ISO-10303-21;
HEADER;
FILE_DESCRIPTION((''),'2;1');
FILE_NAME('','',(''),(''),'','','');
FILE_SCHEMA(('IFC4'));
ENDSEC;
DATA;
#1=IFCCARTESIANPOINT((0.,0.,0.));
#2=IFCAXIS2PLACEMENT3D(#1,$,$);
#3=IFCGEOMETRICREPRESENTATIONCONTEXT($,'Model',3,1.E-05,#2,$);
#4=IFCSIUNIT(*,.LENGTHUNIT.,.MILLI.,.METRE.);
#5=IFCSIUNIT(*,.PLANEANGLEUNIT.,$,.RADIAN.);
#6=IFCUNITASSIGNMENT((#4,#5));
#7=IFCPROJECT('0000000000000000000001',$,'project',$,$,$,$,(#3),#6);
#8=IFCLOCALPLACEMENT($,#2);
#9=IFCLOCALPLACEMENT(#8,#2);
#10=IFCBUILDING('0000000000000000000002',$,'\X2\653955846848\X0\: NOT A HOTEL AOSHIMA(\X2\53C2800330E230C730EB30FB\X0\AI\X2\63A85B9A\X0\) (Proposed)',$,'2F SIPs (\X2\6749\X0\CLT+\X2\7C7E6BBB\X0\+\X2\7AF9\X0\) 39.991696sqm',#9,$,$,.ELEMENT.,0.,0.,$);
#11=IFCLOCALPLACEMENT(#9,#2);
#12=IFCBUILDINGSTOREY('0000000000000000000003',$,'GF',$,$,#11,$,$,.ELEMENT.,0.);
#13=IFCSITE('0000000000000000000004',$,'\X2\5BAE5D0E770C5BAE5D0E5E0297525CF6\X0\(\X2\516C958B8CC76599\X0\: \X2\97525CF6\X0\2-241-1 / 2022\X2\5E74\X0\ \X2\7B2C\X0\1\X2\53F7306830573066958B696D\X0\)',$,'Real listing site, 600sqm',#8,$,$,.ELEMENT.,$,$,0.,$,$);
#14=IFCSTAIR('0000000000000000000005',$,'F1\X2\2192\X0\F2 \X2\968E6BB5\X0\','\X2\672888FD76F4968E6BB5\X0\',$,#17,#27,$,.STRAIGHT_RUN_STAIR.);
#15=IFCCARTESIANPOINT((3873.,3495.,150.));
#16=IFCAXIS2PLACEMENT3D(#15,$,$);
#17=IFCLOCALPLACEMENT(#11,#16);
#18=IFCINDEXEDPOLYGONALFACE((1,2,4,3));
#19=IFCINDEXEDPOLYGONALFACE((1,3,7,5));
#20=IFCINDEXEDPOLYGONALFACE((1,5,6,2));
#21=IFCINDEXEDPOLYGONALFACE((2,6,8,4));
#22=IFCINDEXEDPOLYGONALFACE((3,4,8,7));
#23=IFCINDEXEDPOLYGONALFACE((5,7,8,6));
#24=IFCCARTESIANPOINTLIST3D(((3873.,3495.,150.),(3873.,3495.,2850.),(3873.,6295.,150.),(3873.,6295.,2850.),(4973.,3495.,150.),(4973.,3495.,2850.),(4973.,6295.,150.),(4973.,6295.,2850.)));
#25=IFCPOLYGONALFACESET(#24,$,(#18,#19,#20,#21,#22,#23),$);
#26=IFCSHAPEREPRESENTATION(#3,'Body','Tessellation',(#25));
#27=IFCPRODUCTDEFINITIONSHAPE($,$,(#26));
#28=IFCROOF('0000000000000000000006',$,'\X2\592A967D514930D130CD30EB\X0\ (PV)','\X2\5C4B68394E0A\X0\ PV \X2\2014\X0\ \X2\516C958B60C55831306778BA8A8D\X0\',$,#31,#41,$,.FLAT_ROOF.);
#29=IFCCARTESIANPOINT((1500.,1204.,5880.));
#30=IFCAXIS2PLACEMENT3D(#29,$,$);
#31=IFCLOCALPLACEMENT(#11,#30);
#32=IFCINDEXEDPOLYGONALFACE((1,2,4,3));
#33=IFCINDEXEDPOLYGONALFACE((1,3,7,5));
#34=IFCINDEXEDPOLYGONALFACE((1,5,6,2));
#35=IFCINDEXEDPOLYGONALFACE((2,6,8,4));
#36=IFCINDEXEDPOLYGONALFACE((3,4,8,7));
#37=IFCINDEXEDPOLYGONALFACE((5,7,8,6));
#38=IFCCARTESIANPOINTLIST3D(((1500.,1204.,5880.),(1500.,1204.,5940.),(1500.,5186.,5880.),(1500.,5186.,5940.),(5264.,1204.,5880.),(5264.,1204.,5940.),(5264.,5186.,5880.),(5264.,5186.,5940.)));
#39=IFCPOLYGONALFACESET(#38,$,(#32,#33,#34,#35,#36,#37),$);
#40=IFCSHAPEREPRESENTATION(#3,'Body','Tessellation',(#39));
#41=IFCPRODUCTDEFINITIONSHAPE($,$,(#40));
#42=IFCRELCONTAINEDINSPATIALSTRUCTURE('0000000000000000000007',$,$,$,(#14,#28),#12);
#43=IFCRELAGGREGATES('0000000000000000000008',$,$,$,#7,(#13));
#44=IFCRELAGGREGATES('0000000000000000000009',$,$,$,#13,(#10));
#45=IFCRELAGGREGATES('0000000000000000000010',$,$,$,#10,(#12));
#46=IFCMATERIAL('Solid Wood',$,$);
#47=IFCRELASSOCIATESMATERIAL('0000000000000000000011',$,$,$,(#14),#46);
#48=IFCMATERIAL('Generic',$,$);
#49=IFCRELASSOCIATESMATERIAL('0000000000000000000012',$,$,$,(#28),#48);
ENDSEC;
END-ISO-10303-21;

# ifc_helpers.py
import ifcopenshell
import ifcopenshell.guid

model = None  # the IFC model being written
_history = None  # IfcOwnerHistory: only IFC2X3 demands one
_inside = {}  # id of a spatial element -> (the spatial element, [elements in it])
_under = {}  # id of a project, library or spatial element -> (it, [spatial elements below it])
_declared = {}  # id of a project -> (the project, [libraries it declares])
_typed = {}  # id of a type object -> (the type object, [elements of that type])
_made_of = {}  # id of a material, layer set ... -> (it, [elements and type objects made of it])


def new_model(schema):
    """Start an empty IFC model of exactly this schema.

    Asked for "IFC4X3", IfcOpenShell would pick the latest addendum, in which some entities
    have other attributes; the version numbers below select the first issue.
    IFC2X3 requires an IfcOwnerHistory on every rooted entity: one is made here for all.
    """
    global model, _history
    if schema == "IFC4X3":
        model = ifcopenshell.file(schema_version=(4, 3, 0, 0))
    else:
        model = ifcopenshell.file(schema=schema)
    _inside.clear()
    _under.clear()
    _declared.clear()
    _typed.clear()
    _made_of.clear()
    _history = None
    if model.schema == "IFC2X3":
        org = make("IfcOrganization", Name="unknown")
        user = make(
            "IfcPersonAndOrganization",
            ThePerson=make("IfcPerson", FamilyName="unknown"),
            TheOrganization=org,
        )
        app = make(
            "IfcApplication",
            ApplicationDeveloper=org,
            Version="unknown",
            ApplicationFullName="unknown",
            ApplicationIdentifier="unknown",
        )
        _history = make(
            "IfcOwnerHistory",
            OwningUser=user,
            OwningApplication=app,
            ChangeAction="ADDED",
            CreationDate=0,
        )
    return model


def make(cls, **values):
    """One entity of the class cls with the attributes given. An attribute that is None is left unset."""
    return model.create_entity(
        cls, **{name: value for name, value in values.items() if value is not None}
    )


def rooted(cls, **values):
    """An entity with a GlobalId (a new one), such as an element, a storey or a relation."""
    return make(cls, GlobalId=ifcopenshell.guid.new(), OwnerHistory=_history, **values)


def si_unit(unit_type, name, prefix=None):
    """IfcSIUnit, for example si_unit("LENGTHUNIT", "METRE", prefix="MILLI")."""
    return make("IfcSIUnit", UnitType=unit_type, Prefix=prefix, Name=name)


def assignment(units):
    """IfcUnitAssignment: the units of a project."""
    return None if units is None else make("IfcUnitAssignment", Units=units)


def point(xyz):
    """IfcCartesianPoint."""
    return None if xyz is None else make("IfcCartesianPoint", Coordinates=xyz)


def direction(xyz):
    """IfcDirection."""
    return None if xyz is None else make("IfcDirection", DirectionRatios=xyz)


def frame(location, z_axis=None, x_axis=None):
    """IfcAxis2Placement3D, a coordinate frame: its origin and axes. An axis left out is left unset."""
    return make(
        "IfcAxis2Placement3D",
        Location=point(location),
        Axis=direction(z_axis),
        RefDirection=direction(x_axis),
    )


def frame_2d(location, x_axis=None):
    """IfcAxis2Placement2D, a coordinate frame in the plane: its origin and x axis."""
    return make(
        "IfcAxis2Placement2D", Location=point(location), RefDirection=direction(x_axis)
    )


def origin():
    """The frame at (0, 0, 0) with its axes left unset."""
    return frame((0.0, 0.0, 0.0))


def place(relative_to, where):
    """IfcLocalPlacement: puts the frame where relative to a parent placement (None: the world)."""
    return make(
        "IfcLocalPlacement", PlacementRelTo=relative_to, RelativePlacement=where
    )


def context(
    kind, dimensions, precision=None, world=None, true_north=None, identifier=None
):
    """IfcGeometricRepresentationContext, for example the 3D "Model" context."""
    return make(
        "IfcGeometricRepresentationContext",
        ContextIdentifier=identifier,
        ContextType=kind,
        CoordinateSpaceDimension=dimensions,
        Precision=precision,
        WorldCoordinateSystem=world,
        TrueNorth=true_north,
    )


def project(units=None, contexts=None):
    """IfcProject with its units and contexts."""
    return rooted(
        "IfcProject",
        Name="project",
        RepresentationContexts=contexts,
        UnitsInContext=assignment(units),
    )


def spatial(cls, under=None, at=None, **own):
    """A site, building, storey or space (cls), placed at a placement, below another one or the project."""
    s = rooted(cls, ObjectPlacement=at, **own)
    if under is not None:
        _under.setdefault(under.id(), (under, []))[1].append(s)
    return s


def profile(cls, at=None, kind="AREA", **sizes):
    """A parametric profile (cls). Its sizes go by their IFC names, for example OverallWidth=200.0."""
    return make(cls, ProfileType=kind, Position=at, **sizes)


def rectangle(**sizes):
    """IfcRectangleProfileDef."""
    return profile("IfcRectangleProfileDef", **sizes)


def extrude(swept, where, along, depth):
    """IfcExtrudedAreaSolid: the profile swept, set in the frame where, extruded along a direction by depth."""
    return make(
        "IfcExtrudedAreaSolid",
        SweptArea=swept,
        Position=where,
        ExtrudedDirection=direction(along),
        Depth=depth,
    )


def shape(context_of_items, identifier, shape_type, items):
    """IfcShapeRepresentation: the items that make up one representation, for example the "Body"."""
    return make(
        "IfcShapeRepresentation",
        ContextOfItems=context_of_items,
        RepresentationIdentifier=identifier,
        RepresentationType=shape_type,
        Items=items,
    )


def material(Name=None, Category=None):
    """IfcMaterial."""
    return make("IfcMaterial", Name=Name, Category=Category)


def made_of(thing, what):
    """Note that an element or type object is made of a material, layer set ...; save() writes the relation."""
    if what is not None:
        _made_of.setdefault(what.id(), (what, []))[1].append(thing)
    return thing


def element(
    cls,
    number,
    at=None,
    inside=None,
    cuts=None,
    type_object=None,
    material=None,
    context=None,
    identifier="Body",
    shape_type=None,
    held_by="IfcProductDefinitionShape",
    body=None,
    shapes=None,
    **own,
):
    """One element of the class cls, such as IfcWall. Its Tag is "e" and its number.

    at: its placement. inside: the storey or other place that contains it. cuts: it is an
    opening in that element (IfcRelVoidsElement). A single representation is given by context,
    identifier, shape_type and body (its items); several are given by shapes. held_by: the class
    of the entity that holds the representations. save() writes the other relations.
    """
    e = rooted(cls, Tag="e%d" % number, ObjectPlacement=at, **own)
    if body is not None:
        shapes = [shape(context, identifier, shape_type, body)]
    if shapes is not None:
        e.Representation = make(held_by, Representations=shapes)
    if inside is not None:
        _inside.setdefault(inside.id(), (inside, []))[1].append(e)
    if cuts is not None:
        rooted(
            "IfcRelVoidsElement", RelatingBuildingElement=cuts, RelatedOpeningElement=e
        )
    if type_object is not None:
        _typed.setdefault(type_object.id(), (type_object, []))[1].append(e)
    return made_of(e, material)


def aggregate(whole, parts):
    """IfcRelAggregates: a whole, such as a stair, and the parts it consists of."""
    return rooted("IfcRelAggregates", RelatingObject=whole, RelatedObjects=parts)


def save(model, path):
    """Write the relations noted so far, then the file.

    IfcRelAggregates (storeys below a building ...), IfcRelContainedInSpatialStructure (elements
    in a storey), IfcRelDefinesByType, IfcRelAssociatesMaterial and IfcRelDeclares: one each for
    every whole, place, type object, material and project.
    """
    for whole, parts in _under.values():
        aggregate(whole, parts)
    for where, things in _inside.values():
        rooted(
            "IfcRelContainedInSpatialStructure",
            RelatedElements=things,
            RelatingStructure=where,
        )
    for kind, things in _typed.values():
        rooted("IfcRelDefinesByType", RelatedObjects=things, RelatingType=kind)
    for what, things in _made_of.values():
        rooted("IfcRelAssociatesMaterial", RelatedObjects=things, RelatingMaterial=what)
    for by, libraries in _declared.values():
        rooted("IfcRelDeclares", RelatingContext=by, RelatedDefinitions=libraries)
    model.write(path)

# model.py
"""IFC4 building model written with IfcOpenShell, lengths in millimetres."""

from ifc_helpers import new_model, si_unit, frame, frame_2d, origin, place, context, project, spatial, rectangle, extrude, material, element, save


model = new_model("IFC4")

# Units and contexts
model_context = context("Model", 3, precision=1e-05, world=origin())
ifc_project = project(units=[si_unit("LENGTHUNIT", "METRE", prefix="MILLI"), si_unit("PLANEANGLEUNIT", "RADIAN")], contexts=[model_context])

# Site, building, storey
site_placement = place(None, origin())
site = spatial("IfcSite", under=ifc_project, at=site_placement, Name="宮崎県宮崎市青島(公開資料: 青島2-241-1 / 2022年 第1号として開業)", ObjectType="Real listing site, 600sqm", CompositionType="ELEMENT", RefElevation=0.0)
building_placement = place(site_placement, origin())
building = spatial("IfcBuilding", under=site, at=building_placement, Name="改善案: NOT A HOTEL AOSHIMA(参考モデル・AI推定) (Proposed)", ObjectType="2F SIPs (杉CLT+籾殻+竹) 39.991696sqm", CompositionType="ELEMENT", ElevationOfRefHeight=0.0, ElevationOfTerrain=0.0)
storey_placement = place(building_placement, origin())
storey = spatial("IfcBuildingStorey", under=building, at=storey_placement, Name="GF", CompositionType="ELEMENT", Elevation=0.0)

# Shared definitions
ifc_material_1 = material(Name="Generic")

# Stair
ifc_material_2 = material(Name="Solid Wood")
stair_placement = place(storey_placement, frame((3873.0, 3495.0, 150.0)))
element("IfcStair", 1, at=stair_placement, inside=storey, material=ifc_material_2, Name="F1→F2 階段", Description="木製直階段", PredefinedType="STRAIGHT_RUN_STAIR", context=model_context, shape_type="SweptSolid", body=[
    extrude(rectangle(XDim=1100.0, YDim=2800.0, at=frame_2d((550.0, 1400.0))), frame((3873.0, 3495.0, 150.0)), (0.0, 0.0, 1.0), 2700.0),
])

# Roof
roof_placement = place(storey_placement, frame((1500.0, 1204.0, 5880.0)))
element("IfcRoof", 2, at=roof_placement, inside=storey, material=ifc_material_1, Name="太陽光パネル (PV)", Description="屋根上 PV — 公開情報で確認", PredefinedType="FLAT_ROOF", context=model_context, shape_type="SweptSolid", body=[
    extrude(rectangle(XDim=3764.0, YDim=3982.0, at=frame_2d((1882.0, 1991.0))), frame((1500.0, 1204.0, 5880.0)), (0.0, 0.0, 1.0), 60.0),
])

save(model, "model.ifc")
